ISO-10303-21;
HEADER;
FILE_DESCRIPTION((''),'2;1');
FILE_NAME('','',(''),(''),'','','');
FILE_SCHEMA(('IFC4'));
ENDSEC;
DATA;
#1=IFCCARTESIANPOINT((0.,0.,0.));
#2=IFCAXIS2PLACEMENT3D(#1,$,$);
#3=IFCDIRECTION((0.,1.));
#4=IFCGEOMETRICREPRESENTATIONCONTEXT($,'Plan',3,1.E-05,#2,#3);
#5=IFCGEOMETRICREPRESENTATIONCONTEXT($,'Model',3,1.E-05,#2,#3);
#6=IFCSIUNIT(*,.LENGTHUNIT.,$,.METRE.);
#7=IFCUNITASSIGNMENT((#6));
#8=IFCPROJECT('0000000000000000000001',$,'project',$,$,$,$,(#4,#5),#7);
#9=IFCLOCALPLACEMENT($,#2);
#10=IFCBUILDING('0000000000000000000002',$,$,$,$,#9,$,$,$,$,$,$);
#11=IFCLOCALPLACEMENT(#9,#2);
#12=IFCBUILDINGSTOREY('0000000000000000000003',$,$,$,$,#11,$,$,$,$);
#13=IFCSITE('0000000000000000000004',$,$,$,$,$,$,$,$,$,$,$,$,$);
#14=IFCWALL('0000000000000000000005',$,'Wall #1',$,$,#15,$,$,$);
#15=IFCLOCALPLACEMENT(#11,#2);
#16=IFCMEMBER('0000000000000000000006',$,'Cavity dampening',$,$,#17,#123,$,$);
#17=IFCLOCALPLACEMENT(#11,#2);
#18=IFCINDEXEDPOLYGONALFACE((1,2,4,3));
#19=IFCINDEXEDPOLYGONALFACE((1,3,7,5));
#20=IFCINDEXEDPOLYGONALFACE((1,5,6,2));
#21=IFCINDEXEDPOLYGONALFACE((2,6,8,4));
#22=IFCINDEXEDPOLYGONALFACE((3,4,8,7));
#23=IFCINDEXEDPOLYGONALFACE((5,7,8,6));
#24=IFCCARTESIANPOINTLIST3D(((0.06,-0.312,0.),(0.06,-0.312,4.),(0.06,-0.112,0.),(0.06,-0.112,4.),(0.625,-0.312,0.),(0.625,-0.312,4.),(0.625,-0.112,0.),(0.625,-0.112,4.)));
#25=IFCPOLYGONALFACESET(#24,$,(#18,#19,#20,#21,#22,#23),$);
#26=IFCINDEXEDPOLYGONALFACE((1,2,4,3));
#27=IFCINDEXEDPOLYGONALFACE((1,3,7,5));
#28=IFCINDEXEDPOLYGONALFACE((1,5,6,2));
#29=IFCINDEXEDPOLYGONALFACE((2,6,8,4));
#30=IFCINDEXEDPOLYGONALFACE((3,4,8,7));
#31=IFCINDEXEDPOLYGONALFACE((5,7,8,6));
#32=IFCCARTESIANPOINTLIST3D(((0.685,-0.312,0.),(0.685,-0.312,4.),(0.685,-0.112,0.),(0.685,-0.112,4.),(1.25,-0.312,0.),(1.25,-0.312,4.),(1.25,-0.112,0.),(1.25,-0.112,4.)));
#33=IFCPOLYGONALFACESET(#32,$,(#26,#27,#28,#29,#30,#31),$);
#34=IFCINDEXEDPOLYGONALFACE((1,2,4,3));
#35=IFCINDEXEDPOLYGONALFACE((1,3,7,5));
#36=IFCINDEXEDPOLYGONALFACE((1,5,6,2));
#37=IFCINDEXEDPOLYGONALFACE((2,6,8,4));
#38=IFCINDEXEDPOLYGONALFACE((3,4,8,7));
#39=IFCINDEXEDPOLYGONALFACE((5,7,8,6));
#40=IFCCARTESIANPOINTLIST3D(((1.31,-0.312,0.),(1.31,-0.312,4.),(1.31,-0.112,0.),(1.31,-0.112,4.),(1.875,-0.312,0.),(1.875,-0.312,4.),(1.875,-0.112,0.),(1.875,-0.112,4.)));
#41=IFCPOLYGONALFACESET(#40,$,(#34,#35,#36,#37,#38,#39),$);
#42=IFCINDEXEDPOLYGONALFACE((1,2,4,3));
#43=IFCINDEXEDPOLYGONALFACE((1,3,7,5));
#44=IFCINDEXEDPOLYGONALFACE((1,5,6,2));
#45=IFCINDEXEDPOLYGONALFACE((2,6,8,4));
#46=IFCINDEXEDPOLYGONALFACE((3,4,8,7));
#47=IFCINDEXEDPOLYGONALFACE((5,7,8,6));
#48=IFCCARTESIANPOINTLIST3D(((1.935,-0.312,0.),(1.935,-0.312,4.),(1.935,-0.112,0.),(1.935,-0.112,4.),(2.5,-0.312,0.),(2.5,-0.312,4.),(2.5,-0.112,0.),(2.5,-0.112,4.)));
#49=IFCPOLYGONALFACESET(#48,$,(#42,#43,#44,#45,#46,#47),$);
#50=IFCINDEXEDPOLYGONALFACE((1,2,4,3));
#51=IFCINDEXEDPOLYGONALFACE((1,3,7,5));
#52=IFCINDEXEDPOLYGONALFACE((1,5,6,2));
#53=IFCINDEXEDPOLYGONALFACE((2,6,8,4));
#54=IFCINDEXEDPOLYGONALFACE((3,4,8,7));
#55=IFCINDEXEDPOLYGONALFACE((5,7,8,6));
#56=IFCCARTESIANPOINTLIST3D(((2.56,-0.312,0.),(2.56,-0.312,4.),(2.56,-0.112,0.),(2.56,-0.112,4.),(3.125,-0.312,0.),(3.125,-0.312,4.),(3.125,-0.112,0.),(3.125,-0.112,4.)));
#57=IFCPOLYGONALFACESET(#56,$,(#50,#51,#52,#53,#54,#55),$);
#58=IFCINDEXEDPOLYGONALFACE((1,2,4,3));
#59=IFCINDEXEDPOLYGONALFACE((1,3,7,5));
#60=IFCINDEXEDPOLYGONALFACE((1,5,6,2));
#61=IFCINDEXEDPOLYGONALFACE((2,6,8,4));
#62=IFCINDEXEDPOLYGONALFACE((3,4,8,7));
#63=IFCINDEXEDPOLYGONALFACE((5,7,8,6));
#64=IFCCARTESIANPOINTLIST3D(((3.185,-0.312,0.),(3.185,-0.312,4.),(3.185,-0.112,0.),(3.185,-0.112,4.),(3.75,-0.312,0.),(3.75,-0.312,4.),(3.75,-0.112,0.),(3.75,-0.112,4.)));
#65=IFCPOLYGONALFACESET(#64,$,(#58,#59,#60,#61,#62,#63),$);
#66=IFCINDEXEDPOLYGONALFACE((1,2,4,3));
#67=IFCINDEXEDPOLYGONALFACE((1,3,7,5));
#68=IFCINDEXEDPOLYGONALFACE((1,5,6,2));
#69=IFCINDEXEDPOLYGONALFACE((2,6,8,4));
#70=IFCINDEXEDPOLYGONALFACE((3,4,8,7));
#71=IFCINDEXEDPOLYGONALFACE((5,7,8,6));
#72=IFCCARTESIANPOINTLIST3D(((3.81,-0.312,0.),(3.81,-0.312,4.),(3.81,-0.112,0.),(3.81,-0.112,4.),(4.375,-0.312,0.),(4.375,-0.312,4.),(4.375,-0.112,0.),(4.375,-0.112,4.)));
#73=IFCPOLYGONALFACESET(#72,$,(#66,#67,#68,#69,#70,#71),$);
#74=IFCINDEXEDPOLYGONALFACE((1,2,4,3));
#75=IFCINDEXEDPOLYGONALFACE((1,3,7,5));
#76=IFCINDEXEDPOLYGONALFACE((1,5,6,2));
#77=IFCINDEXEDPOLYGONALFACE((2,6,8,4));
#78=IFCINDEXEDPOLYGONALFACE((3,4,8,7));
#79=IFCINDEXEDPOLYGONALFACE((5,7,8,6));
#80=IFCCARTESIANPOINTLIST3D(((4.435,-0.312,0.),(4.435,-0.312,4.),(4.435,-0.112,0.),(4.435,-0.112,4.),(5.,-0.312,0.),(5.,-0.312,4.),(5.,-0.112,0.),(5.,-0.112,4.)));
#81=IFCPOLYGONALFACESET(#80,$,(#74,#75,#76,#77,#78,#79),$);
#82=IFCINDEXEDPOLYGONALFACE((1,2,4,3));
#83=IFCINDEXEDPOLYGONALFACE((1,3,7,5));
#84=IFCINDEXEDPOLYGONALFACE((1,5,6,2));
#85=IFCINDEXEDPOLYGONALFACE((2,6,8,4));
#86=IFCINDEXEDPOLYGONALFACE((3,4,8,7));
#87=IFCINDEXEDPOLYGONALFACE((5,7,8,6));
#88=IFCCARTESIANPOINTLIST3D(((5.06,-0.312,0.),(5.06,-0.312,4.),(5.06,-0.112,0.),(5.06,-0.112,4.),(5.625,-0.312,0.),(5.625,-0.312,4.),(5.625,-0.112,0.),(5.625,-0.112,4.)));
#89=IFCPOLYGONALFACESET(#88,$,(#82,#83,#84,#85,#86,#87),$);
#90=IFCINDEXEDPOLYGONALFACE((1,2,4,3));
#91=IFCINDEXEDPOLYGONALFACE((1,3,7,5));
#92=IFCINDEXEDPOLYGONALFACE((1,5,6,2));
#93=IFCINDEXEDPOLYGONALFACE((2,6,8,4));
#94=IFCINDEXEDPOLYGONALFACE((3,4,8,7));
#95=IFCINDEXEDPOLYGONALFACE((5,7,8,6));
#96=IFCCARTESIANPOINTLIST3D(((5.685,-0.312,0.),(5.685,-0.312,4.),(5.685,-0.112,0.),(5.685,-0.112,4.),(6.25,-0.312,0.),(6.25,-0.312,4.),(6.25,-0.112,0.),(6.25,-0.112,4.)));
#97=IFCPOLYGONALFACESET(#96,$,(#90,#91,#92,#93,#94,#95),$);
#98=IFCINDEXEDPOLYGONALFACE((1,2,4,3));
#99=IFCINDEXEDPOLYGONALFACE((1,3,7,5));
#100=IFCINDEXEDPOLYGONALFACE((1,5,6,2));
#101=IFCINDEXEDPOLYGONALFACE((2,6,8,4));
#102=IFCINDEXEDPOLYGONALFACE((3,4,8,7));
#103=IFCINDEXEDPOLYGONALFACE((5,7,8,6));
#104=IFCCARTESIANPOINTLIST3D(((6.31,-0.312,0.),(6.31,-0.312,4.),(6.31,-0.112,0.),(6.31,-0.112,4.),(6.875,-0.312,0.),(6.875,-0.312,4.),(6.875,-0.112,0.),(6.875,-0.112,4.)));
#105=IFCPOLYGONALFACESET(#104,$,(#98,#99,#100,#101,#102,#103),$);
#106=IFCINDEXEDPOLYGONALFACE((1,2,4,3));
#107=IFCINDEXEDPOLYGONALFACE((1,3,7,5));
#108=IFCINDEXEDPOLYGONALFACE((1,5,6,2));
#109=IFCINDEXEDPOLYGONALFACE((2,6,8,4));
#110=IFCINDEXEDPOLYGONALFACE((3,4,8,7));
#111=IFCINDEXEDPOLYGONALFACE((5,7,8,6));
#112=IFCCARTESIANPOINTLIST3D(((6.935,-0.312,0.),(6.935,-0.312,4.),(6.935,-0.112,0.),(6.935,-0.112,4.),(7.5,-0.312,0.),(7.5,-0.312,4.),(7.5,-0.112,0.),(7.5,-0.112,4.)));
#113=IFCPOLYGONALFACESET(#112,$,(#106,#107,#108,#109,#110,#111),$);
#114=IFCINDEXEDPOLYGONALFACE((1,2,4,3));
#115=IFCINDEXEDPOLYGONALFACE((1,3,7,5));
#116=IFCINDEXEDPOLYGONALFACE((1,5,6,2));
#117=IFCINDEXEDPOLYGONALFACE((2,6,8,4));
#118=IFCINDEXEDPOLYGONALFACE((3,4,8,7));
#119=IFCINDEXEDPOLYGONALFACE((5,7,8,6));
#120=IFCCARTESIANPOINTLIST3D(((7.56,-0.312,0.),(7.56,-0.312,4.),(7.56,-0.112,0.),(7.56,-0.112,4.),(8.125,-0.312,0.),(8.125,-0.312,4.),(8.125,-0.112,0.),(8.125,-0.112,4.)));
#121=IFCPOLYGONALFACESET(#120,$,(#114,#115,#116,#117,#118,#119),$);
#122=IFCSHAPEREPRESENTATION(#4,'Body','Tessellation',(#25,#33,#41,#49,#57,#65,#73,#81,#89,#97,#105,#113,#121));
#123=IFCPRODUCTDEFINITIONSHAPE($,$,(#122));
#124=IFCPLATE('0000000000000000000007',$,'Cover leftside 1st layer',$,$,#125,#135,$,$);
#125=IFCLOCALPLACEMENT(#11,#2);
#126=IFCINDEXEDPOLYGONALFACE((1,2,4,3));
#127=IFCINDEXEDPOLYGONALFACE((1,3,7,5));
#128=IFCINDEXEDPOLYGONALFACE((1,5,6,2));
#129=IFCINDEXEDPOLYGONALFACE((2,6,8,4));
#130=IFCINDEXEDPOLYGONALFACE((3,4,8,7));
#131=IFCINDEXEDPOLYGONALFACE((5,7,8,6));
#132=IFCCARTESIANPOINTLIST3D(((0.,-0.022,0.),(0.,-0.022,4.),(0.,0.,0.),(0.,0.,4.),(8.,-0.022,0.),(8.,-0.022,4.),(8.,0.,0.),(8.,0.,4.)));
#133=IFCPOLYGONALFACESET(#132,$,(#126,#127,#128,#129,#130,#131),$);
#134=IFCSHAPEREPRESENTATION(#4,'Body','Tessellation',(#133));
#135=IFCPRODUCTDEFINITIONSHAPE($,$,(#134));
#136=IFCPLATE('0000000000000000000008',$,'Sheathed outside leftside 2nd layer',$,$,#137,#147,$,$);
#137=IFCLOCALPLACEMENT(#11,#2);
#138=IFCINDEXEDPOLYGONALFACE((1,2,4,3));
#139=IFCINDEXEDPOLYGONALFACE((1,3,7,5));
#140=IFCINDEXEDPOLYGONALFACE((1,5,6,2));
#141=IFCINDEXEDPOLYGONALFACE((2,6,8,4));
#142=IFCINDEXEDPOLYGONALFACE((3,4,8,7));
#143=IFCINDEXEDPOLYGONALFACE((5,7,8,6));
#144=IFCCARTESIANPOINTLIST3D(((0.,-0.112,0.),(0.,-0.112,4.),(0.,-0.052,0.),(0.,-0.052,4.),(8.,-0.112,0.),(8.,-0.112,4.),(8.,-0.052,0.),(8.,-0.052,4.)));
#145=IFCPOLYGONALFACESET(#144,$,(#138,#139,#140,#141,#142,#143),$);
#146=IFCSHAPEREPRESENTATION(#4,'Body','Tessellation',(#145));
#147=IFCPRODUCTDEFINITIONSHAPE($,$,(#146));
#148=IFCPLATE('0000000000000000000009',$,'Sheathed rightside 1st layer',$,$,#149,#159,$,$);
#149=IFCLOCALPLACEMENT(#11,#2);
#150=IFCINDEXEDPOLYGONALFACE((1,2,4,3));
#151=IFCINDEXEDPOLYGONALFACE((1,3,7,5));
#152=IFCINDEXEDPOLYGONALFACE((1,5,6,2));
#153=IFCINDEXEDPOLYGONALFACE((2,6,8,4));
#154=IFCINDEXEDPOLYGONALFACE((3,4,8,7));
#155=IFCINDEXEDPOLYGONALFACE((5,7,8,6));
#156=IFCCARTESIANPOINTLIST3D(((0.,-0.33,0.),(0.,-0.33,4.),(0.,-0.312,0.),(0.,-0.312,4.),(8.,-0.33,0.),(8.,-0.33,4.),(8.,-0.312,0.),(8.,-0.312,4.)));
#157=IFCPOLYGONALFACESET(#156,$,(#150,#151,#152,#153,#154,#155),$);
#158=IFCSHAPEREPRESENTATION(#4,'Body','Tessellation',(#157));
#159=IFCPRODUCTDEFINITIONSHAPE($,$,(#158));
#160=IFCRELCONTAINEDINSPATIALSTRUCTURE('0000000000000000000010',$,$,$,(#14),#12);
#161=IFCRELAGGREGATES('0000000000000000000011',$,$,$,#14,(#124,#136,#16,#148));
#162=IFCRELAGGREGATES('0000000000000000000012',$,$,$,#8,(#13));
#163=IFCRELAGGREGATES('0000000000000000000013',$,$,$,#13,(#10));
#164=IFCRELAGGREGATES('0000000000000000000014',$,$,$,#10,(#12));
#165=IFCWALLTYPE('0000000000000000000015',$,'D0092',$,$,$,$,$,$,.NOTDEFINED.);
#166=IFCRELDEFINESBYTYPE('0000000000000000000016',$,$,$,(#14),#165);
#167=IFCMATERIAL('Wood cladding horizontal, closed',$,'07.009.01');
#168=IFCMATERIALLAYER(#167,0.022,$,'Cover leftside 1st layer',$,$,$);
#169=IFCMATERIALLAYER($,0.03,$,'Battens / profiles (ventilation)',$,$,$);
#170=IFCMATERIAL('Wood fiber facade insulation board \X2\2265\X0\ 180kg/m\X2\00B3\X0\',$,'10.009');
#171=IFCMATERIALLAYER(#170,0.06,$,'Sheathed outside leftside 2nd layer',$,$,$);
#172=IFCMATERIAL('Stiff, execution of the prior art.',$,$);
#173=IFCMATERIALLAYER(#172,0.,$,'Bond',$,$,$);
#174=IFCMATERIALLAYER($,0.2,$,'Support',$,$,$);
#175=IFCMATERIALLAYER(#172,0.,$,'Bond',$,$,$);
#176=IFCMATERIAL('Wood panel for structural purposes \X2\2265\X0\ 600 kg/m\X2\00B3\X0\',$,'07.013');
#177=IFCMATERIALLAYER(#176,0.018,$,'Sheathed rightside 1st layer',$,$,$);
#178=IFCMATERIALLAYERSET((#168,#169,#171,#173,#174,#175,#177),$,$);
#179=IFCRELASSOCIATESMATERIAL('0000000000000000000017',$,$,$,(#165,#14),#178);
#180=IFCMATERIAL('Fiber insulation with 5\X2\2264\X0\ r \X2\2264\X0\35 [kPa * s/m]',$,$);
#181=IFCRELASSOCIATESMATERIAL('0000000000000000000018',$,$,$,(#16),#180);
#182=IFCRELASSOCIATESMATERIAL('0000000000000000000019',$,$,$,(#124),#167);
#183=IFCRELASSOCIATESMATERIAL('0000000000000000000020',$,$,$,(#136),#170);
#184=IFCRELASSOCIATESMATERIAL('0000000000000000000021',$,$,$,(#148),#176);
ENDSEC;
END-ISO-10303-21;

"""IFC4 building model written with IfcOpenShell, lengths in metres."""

from ifc_helpers import new_model, si_unit, direction, frame, frame_2d, origin, origin_with_axes, place, context, project, spatial, rectangle, extrude, material, layer, layer_set, type_object, element, aggregate, save


model = new_model("IFC4")

# Units and contexts
plan_context = context("Plan", 3, precision=1e-05, world=origin(), true_north=direction((0.0, 1.0)))
model_context = context("Model", 3, precision=1e-05, world=origin(), true_north=direction((0.0, 1.0)))
ifc_project = project(units=[si_unit("LENGTHUNIT", "METRE")], contexts=[plan_context, model_context])

# Site, building, storey
site = spatial("IfcSite", under=ifc_project)
building_placement = place(None, origin())
building = spatial("IfcBuilding", under=site, at=building_placement)
storey_placement = place(building_placement, origin())
storey = spatial("IfcBuildingStorey", under=building, at=storey_placement)

# Wall, member, plates
ifc_material_1 = material(Name="Wood cladding horizontal, closed", Category="07.009.01")
ifc_layer_1 = layer(ifc_material_1, 0.022, Name="Cover leftside 1st layer")
ifc_layer_2 = layer(None, 0.03, Name="Battens / profiles (ventilation)")
ifc_material_2 = material(Name="Wood fiber facade insulation board ≥ 180kg/m³", Category="10.009")
ifc_layer_3 = layer(ifc_material_2, 0.06, Name="Sheathed outside leftside 2nd layer")
ifc_material_3 = material(Name="Stiff, execution of the prior art.")
ifc_layer_4 = layer(ifc_material_3, 0.0, Name="Bond")
ifc_layer_5 = layer(None, 0.2, Name="Support")
ifc_layer_6 = layer(ifc_material_3, 0.0, Name="Bond")
ifc_material_4 = material(Name="Wood panel for structural purposes ≥ 600 kg/m³", Category="07.013")
ifc_layer_7 = layer(ifc_material_4, 0.018, Name="Sheathed rightside 1st layer")
ifc_layer_set = layer_set([ifc_layer_1, ifc_layer_2, ifc_layer_3, ifc_layer_4, ifc_layer_5, ifc_layer_6, ifc_layer_7])
wall_type = type_object("IfcWallType", Name="D0092", PredefinedType="NOTDEFINED", material=ifc_layer_set)
wall_placement = place(None, frame((0.0, 0.0, 0.0), z_axis=(0.0, -1.0, 0.0), x_axis=(1.0, 0.0, 0.0)))
wall = element("IfcWall", 1, at=wall_placement, inside=storey, type_object=wall_type, material=ifc_layer_set, Name="Wall #1")
ifc_material_5 = material(Name="Fiber insulation with 5≤ r ≤35 [kPa * s/m]")
member_1_placement = place(wall_placement, origin())
member_1 = element("IfcMember", 2, at=member_1_placement, material=ifc_material_5, Name="Cavity dampening", context=plan_context, shape_type="SweptSolid", body=[
    extrude(rectangle(XDim=0.565, YDim=0.2, at=frame_2d((0.2825, 0.1), x_axis=(1.0, 0.0))), frame((0.06, 4.0, 0.112), z_axis=(0.0, -1.0, 0.0), x_axis=(1.0, 0.0, 0.0)), (0.0, 0.0, 1.0), 4.0),
    extrude(rectangle(XDim=0.565, YDim=0.2, at=frame_2d((0.2825, 0.1), x_axis=(1.0, 0.0))), frame((0.685, 4.0, 0.112), z_axis=(0.0, -1.0, 0.0), x_axis=(1.0, 0.0, 0.0)), (0.0, 0.0, 1.0), 4.0),
    extrude(rectangle(XDim=0.565, YDim=0.2, at=frame_2d((0.2825, 0.1), x_axis=(1.0, 0.0))), frame((1.31, 4.0, 0.112), z_axis=(0.0, -1.0, 0.0), x_axis=(1.0, 0.0, 0.0)), (0.0, 0.0, 1.0), 4.0),
    extrude(rectangle(XDim=0.565, YDim=0.2, at=frame_2d((0.2825, 0.1), x_axis=(1.0, 0.0))), frame((1.935, 4.0, 0.112), z_axis=(0.0, -1.0, 0.0), x_axis=(1.0, 0.0, 0.0)), (0.0, 0.0, 1.0), 4.0),
    extrude(rectangle(XDim=0.565, YDim=0.2, at=frame_2d((0.2825, 0.1), x_axis=(1.0, 0.0))), frame((2.56, 4.0, 0.112), z_axis=(0.0, -1.0, 0.0), x_axis=(1.0, 0.0, 0.0)), (0.0, 0.0, 1.0), 4.0),
    extrude(rectangle(XDim=0.565, YDim=0.2, at=frame_2d((0.2825, 0.1), x_axis=(1.0, 0.0))), frame((3.185, 4.0, 0.112), z_axis=(0.0, -1.0, 0.0), x_axis=(1.0, 0.0, 0.0)), (0.0, 0.0, 1.0), 4.0),
    extrude(rectangle(XDim=0.565, YDim=0.2, at=frame_2d((0.2825, 0.1), x_axis=(1.0, 0.0))), frame((3.81, 4.0, 0.112), z_axis=(0.0, -1.0, 0.0), x_axis=(1.0, 0.0, 0.0)), (0.0, 0.0, 1.0), 4.0),
    extrude(rectangle(XDim=0.565, YDim=0.2, at=frame_2d((0.2825, 0.1), x_axis=(1.0, 0.0))), frame((4.435, 4.0, 0.112), z_axis=(0.0, -1.0, 0.0), x_axis=(1.0, 0.0, 0.0)), (0.0, 0.0, 1.0), 4.0),
    extrude(rectangle(XDim=0.565, YDim=0.2, at=frame_2d((0.2825, 0.1), x_axis=(1.0, 0.0))), frame((5.06, 4.0, 0.112), z_axis=(0.0, -1.0, 0.0), x_axis=(1.0, 0.0, 0.0)), (0.0, 0.0, 1.0), 4.0),
    extrude(rectangle(XDim=0.565, YDim=0.2, at=frame_2d((0.2825, 0.1), x_axis=(1.0, 0.0))), frame((5.685, 4.0, 0.112), z_axis=(0.0, -1.0, 0.0), x_axis=(1.0, 0.0, 0.0)), (0.0, 0.0, 1.0), 4.0),
    extrude(rectangle(XDim=0.565, YDim=0.2, at=frame_2d((0.2825, 0.1), x_axis=(1.0, 0.0))), frame((6.31, 4.0, 0.112), z_axis=(0.0, -1.0, 0.0), x_axis=(1.0, 0.0, 0.0)), (0.0, 0.0, 1.0), 4.0),
    extrude(rectangle(XDim=0.565, YDim=0.2, at=frame_2d((0.2825, 0.1), x_axis=(1.0, 0.0))), frame((6.935, 4.0, 0.112), z_axis=(0.0, -1.0, 0.0), x_axis=(1.0, 0.0, 0.0)), (0.0, 0.0, 1.0), 4.0),
    extrude(rectangle(XDim=0.565, YDim=0.2, at=frame_2d((0.2825, 0.1), x_axis=(1.0, 0.0))), frame((7.56, 4.0, 0.112), z_axis=(0.0, -1.0, 0.0), x_axis=(1.0, 0.0, 0.0)), (0.0, 0.0, 1.0), 4.0),
])
plate_1_placement = place(wall_placement, origin())
plate_1 = element("IfcPlate", 3, at=plate_1_placement, material=ifc_material_1, Name="Cover leftside 1st layer", context=plan_context, shape_type="SweptSolid", body=[
    extrude(rectangle(XDim=8.0, YDim=4.0, at=frame_2d((4.0, 2.0), x_axis=(1.0, 0.0))), origin_with_axes(), (0.0, 0.0, 1.0), 0.022),
])
plate_2_placement = place(wall_placement, origin())
plate_2 = element("IfcPlate", 4, at=plate_2_placement, material=ifc_material_2, Name="Sheathed outside leftside 2nd layer", context=plan_context, shape_type="SweptSolid", body=[
    extrude(rectangle(XDim=8.0, YDim=4.0, at=frame_2d((4.0, 2.0), x_axis=(1.0, 0.0))), frame((0.0, 0.0, 0.052), z_axis=(0.0, 0.0, 1.0), x_axis=(1.0, 0.0, 0.0)), (0.0, 0.0, 1.0), 0.06),
])
plate_3_placement = place(wall_placement, origin())
plate_3 = element("IfcPlate", 5, at=plate_3_placement, material=ifc_material_4, Name="Sheathed rightside 1st layer", context=plan_context, shape_type="SweptSolid", body=[
    extrude(rectangle(XDim=8.0, YDim=4.0, at=frame_2d((4.0, 2.0), x_axis=(1.0, 0.0))), frame((0.0, 0.0, 0.312), z_axis=(0.0, 0.0, 1.0), x_axis=(1.0, 0.0, 0.0)), (0.0, 0.0, 1.0), 0.018),
])
aggregate(wall, [plate_1, plate_2, member_1, plate_3])

save(model, "model.ifc")
